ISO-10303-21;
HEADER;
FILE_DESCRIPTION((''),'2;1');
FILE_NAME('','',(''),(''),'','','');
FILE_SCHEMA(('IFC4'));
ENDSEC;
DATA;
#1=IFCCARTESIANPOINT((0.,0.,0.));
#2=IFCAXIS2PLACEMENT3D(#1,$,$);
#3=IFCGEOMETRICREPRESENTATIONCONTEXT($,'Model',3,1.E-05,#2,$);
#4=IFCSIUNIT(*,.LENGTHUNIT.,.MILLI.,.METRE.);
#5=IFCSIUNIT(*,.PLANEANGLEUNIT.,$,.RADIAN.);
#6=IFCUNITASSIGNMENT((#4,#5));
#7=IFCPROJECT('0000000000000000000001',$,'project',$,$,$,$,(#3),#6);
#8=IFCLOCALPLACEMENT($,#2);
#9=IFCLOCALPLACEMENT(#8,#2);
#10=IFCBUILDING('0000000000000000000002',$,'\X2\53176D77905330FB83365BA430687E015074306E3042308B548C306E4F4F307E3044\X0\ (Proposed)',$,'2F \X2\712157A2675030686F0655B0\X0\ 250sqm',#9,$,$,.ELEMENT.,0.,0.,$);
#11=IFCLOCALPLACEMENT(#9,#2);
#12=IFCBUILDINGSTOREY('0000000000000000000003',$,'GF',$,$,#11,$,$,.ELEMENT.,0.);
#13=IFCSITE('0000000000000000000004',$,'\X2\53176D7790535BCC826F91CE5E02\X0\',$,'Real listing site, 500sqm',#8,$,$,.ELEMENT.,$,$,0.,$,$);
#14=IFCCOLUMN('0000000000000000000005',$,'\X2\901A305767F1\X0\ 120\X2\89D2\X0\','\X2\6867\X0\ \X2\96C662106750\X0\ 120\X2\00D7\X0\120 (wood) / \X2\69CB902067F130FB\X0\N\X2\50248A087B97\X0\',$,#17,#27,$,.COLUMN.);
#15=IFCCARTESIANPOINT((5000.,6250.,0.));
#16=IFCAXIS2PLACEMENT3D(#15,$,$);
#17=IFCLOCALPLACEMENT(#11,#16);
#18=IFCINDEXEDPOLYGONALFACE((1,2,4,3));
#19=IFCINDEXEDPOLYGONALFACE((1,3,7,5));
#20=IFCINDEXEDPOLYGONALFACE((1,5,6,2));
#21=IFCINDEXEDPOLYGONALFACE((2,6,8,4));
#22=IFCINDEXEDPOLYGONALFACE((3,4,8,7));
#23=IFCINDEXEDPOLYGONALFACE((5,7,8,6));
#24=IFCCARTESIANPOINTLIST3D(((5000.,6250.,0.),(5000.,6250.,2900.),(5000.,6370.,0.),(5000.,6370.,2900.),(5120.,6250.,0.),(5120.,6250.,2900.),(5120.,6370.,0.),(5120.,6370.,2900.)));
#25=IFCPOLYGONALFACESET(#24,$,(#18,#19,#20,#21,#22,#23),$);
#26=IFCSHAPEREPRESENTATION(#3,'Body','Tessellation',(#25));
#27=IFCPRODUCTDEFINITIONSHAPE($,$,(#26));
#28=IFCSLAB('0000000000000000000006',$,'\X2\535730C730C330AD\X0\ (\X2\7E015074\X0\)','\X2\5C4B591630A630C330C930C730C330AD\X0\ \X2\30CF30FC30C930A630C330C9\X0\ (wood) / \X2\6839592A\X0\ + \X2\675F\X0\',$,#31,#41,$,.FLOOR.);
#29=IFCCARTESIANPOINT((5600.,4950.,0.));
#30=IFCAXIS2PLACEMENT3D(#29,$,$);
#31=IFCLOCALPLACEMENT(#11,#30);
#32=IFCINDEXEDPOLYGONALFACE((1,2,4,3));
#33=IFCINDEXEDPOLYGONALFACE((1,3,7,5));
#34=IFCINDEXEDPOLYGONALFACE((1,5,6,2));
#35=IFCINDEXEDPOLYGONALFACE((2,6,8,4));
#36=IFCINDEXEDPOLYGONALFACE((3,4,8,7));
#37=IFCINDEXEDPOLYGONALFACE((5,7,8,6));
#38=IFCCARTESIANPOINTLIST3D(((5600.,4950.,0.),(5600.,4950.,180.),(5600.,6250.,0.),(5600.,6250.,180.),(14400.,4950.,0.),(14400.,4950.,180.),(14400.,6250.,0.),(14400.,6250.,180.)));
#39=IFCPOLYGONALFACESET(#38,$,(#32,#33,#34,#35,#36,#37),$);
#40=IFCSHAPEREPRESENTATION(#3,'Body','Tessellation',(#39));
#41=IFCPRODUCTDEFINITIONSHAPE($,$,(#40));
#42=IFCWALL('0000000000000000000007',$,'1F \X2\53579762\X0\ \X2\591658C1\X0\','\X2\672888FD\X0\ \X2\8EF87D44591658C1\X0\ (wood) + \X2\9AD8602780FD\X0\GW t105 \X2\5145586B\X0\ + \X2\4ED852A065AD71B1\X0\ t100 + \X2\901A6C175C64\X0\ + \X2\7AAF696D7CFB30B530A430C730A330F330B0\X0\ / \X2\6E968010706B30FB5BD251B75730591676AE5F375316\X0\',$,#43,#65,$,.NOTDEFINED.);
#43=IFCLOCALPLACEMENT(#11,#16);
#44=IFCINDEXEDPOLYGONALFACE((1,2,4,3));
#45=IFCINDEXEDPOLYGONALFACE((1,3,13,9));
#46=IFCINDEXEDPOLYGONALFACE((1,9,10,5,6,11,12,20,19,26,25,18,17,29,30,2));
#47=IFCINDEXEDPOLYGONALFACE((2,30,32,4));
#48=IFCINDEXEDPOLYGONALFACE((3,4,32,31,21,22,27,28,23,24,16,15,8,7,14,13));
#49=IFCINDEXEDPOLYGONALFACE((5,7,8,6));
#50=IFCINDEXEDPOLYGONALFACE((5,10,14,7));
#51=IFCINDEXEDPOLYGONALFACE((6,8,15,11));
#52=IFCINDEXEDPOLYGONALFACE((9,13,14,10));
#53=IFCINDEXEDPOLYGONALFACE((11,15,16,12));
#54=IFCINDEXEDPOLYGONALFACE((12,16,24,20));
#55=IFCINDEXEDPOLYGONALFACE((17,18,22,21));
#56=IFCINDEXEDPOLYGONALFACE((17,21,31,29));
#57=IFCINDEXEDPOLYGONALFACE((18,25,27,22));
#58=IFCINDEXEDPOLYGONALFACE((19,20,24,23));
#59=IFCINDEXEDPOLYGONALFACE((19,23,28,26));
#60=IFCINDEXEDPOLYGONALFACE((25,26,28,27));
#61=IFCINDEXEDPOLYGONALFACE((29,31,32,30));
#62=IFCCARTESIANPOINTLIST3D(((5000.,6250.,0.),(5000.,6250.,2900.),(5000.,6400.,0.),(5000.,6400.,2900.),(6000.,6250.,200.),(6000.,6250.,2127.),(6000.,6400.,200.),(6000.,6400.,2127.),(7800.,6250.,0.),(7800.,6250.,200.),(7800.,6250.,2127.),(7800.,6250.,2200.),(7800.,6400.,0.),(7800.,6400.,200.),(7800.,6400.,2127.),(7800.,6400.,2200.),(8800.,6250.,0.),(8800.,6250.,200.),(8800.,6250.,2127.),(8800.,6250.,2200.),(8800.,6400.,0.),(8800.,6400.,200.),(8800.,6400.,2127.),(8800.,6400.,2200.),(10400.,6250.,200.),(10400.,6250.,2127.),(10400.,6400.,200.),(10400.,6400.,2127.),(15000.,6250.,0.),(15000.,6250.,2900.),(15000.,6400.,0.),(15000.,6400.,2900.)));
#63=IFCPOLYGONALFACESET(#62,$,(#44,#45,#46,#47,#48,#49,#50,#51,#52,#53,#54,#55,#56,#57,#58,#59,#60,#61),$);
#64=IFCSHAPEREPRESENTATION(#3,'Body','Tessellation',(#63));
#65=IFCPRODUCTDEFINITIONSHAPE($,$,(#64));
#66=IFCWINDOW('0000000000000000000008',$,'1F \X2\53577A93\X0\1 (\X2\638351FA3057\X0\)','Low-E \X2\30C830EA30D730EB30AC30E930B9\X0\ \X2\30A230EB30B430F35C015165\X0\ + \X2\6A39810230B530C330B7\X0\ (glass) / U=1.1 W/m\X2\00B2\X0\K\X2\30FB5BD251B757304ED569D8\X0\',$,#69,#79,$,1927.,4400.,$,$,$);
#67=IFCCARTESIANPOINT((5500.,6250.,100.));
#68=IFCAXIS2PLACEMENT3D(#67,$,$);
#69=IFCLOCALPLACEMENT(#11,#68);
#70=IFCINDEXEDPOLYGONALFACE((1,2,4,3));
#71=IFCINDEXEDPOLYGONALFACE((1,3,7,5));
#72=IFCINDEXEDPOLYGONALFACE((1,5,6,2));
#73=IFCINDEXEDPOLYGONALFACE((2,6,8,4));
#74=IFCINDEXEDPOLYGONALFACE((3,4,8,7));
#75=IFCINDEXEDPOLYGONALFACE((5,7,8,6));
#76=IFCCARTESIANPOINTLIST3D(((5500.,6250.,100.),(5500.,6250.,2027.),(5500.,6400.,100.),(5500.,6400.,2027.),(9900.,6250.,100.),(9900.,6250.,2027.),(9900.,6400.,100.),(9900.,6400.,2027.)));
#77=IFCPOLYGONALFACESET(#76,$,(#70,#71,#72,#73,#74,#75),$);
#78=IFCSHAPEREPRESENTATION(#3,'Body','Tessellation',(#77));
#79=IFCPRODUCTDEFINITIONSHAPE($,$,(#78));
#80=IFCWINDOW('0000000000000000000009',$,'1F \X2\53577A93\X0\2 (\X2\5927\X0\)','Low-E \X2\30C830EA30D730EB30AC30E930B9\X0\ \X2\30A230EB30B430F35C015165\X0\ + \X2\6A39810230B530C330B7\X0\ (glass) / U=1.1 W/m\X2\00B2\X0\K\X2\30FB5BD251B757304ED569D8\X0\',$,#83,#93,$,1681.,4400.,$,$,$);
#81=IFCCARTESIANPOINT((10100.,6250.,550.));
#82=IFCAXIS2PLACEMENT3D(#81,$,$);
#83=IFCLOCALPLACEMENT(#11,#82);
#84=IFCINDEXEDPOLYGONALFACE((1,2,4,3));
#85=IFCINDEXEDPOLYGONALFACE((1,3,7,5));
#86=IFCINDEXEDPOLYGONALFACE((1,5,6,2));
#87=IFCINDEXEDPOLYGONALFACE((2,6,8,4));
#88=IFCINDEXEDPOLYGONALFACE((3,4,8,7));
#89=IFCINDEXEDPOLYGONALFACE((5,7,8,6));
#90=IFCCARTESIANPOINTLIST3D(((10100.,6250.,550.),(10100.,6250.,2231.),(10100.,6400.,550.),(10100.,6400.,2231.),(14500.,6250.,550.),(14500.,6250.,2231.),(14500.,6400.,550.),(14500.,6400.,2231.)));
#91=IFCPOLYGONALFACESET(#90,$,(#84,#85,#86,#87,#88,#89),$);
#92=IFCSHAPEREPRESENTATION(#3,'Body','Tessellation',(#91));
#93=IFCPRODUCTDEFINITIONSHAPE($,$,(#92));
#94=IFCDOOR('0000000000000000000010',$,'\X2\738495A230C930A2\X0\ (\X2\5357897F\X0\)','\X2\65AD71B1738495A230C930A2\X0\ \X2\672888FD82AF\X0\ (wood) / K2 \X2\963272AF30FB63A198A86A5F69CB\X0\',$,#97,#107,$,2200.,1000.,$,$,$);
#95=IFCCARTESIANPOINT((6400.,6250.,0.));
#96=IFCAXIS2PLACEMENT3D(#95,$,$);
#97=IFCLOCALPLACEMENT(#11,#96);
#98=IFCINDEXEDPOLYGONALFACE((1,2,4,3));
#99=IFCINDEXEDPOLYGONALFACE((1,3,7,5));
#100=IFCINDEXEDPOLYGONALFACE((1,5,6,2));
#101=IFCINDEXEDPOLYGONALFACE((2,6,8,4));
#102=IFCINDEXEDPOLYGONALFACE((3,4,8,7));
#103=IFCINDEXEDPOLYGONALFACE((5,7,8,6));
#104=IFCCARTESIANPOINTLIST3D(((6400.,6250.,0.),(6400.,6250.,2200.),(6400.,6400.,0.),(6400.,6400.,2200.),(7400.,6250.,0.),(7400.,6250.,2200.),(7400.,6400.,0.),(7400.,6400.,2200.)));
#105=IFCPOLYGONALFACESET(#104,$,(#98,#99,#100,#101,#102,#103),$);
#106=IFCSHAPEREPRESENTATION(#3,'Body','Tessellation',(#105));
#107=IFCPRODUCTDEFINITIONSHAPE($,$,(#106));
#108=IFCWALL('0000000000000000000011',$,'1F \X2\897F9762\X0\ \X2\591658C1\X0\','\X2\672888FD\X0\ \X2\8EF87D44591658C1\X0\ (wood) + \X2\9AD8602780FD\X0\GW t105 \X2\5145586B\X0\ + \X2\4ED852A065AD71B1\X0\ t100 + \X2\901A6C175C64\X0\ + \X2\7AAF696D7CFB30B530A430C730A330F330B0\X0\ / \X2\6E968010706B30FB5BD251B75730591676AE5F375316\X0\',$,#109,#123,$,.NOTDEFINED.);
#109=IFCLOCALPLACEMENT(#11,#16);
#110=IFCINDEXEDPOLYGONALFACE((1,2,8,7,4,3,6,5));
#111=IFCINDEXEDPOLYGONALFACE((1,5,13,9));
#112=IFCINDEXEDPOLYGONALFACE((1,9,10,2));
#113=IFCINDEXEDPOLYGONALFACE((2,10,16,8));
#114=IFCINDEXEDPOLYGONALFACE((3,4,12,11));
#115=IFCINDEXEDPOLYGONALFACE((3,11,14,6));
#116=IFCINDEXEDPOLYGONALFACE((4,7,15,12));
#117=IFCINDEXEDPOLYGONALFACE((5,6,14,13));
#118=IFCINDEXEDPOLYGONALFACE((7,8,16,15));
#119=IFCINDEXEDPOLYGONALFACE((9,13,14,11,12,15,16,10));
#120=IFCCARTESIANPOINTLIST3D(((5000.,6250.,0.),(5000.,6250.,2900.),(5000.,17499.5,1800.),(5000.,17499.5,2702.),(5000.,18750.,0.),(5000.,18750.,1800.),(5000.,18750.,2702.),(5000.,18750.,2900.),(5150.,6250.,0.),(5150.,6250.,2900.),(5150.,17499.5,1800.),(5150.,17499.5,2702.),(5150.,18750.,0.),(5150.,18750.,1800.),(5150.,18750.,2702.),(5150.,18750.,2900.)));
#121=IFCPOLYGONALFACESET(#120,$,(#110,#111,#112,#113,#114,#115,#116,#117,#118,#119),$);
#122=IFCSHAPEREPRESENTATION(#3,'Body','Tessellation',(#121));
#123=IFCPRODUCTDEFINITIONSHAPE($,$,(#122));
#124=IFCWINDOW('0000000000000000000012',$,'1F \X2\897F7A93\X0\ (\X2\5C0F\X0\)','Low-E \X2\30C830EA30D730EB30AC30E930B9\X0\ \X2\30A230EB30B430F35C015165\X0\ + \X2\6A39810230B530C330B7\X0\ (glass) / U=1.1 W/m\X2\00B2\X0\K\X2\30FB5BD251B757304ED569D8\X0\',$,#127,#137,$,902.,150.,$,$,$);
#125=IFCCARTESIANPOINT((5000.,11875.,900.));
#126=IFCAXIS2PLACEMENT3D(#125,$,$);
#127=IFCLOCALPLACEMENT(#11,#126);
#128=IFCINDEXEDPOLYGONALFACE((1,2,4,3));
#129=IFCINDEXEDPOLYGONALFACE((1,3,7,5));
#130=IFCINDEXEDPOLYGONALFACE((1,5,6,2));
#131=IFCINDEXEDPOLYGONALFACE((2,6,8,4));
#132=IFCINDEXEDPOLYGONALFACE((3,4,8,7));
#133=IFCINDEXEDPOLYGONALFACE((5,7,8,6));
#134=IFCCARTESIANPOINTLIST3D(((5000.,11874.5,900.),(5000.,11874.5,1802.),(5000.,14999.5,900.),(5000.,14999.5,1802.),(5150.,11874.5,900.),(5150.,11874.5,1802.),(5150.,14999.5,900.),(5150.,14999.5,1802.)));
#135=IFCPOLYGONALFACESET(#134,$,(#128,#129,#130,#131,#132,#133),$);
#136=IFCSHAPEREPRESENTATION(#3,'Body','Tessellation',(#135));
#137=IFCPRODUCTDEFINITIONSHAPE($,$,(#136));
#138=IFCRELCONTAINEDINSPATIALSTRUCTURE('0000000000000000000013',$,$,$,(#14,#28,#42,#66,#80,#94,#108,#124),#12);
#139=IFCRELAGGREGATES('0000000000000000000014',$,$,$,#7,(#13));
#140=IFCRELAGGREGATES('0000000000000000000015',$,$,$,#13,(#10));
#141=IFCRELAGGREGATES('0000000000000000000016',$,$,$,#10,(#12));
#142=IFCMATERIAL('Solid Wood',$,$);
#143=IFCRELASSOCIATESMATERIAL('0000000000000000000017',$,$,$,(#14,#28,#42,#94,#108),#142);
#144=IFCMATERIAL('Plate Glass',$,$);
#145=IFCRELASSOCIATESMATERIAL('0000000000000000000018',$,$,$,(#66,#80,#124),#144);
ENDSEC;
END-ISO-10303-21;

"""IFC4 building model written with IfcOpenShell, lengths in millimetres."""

from ifc_helpers import new_model, si_unit, frame, frame_2d, origin, place, context, project, spatial, rectangle, extrude, material, element, fill, save


model = new_model("IFC4")

# Units and contexts
model_context = context("Model", 3, precision=1e-05, world=origin())
ifc_project = project(units=[si_unit("LENGTHUNIT", "METRE", prefix="MILLI"), si_unit("PLANEANGLEUNIT", "RADIAN")], contexts=[model_context])

# Site, building, storey
site_placement = place(None, origin())
site = spatial("IfcSite", under=ifc_project, at=site_placement, Name="北海道富良野市", ObjectType="Real listing site, 500sqm", CompositionType="ELEMENT", RefElevation=0.0)
building_placement = place(site_placement, origin())
building = spatial("IfcBuilding", under=site, at=building_placement, Name="北海道・茶室と縁側のある和の住まい (Proposed)", ObjectType="2F 無垢材と漆喰 250sqm", CompositionType="ELEMENT", ElevationOfRefHeight=0.0, ElevationOfTerrain=0.0)
storey_placement = place(building_placement, origin())
storey = spatial("IfcBuildingStorey", under=building, at=storey_placement, Name="GF", CompositionType="ELEMENT", Elevation=0.0)

# Column
ifc_material_1 = material(Name="Solid Wood")
column_placement = place(storey_placement, frame((5000.0, 6250.0, 0.0)))
element("IfcColumn", 1, at=column_placement, inside=storey, material=ifc_material_1, Name="通し柱 120角", Description="桧 集成材 120×120 (wood) / 構造柱・N値計算", PredefinedType="COLUMN", context=model_context, shape_type="SweptSolid", body=[
    extrude(rectangle(XDim=120.0, YDim=120.0, at=frame_2d((60.0, 60.0))), frame((5000.0, 6250.0, 0.0)), (0.0, 0.0, 1.0), 2900.0),
])

# Slab
slab_1_placement = place(storey_placement, frame((5600.0, 4950.0, 0.0)))
element("IfcSlab", 2, at=slab_1_placement, inside=storey, material=ifc_material_1, Name="南デッキ (縁側)", Description="屋外ウッドデッキ ハードウッド (wood) / 根太 + 束", PredefinedType="FLOOR", context=model_context, shape_type="SweptSolid", body=[
    extrude(rectangle(XDim=8800.0, YDim=1300.0, at=frame_2d((4400.0, 650.0))), frame((5600.0, 4950.0, 0.0)), (0.0, 0.0, 1.0), 180.0),
])

# Wall, openings, windows, door
wall_1_placement = place(storey_placement, frame((5000.0, 6250.0, 0.0)))
wall_1 = element("IfcWall", 3, at=wall_1_placement, inside=storey, material=ifc_material_1, Name="1F 南面 外壁", Description="木製 軸組外壁 (wood) + 高性能GW t105 充填 + 付加断熱 t100 + 通気層 + 窯業系サイディング / 準耐火・寒冷地外皮強化", PredefinedType="NOTDEFINED", context=model_context, shape_type="SweptSolid", body=[
    extrude(rectangle(XDim=10000.0, YDim=150.0, at=frame_2d((5000.0, 75.0))), frame((5000.0, 6250.0, 0.0)), (0.0, 0.0, 1.0), 2900.0),
])
opening_1_placement = place(storey_placement, frame((5500.0, 6250.0, 100.0)))
opening_1 = element("IfcOpeningElement", 4, at=opening_1_placement, cuts=wall_1, PredefinedType="NOTDEFINED", context=model_context, shape_type="SweptSolid", body=[
    extrude(rectangle(XDim=4400.0, YDim=150.0, at=frame_2d((2200.0, 75.0))), frame((5500.0, 6250.0, 100.0)), (0.0, 0.0, 1.0), 1927.0),
])
opening_2_placement = place(storey_placement, frame((10100.0, 6250.0, 550.0)))
opening_2 = element("IfcOpeningElement", 5, at=opening_2_placement, cuts=wall_1, PredefinedType="NOTDEFINED", context=model_context, shape_type="SweptSolid", body=[
    extrude(rectangle(XDim=4400.0, YDim=150.0, at=frame_2d((2200.0, 75.0))), frame((10100.0, 6250.0, 550.0)), (0.0, 0.0, 1.0), 1681.0),
])
opening_3_placement = place(storey_placement, frame((6400.0, 6250.0, 0.0)))
opening_3 = element("IfcOpeningElement", 6, at=opening_3_placement, cuts=wall_1, PredefinedType="NOTDEFINED", context=model_context, shape_type="SweptSolid", body=[
    extrude(rectangle(XDim=1000.0, YDim=150.0, at=frame_2d((500.0, 75.0))), frame((6400.0, 6250.0, 0.0)), (0.0, 0.0, 1.0), 2200.0),
])
ifc_material_2 = material(Name="Plate Glass")
window_1_placement = place(storey_placement, frame((5500.0, 6250.0, 100.0)))
window_1 = element("IfcWindow", 7, at=window_1_placement, inside=storey, material=ifc_material_2, Name="1F 南窓1 (掃出し)", Description="Low-E トリプルガラス アルゴン封入 + 樹脂サッシ (glass) / U=1.1 W/m²K・寒冷地仕様", OverallHeight=1927.0, OverallWidth=4400.0, context=model_context, shape_type="SweptSolid", body=[
    extrude(rectangle(XDim=4400.0, YDim=150.0, at=frame_2d((2200.0, 75.0))), frame((5500.0, 6250.0, 100.0)), (0.0, 0.0, 1.0), 1927.0),
])
fill(opening_1, window_1)
window_2_placement = place(storey_placement, frame((10100.0, 6250.0, 550.0)))
window_2 = element("IfcWindow", 8, at=window_2_placement, inside=storey, material=ifc_material_2, Name="1F 南窓2 (大)", Description="Low-E トリプルガラス アルゴン封入 + 樹脂サッシ (glass) / U=1.1 W/m²K・寒冷地仕様", OverallHeight=1681.0, OverallWidth=4400.0, context=model_context, shape_type="SweptSolid", body=[
    extrude(rectangle(XDim=4400.0, YDim=150.0, at=frame_2d((2200.0, 75.0))), frame((10100.0, 6250.0, 550.0)), (0.0, 0.0, 1.0), 1681.0),
])
fill(opening_2, window_2)
door_placement = place(storey_placement, frame((6400.0, 6250.0, 0.0)))
door = element("IfcDoor", 9, at=door_placement, inside=storey, material=ifc_material_1, Name="玄関ドア (南西)", Description="断熱玄関ドア 木製芯 (wood) / K2 防犯・採風機構", OverallHeight=2200.0, OverallWidth=1000.0, context=model_context, shape_type="SweptSolid", body=[
    extrude(rectangle(XDim=1000.0, YDim=150.0, at=frame_2d((500.0, 75.0))), frame((6400.0, 6250.0, 0.0)), (0.0, 0.0, 1.0), 2200.0),
])
fill(opening_3, door)

# Wall, opening, window
wall_2_placement = place(storey_placement, frame((5000.0, 6250.0, 0.0)))
wall_2 = element("IfcWall", 10, at=wall_2_placement, inside=storey, material=ifc_material_1, Name="1F 西面 外壁", Description="木製 軸組外壁 (wood) + 高性能GW t105 充填 + 付加断熱 t100 + 通気層 + 窯業系サイディング / 準耐火・寒冷地外皮強化", PredefinedType="NOTDEFINED", context=model_context, shape_type="SweptSolid", body=[
    extrude(rectangle(XDim=150.0, YDim=12500.0, at=frame_2d((75.0, 6250.0))), frame((5000.0, 6250.0, 0.0)), (0.0, 0.0, 1.0), 2900.0),
])
opening_4_placement = place(storey_placement, frame((5000.0, 11875.0, 900.0)))
opening_4 = element("IfcOpeningElement", 11, at=opening_4_placement, cuts=wall_2, PredefinedType="NOTDEFINED", context=model_context, shape_type="SweptSolid", body=[
    extrude(rectangle(XDim=150.0, YDim=3125.0, at=frame_2d((75.0, 1562.0))), frame((5000.0, 11875.0, 900.0)), (0.0, 0.0, 1.0), 902.0),
])
window_3_placement = place(storey_placement, frame((5000.0, 11875.0, 900.0)))
window_3 = element("IfcWindow", 12, at=window_3_placement, inside=storey, material=ifc_material_2, Name="1F 西窓 (小)", Description="Low-E トリプルガラス アルゴン封入 + 樹脂サッシ (glass) / U=1.1 W/m²K・寒冷地仕様", OverallHeight=902.0, OverallWidth=150.0, context=model_context, shape_type="SweptSolid", body=[
    extrude(rectangle(XDim=150.0, YDim=3125.0, at=frame_2d((75.0, 1562.0))), frame((5000.0, 11875.0, 900.0)), (0.0, 0.0, 1.0), 902.0),
])
fill(opening_4, window_3)

save(model, "model.ifc")
